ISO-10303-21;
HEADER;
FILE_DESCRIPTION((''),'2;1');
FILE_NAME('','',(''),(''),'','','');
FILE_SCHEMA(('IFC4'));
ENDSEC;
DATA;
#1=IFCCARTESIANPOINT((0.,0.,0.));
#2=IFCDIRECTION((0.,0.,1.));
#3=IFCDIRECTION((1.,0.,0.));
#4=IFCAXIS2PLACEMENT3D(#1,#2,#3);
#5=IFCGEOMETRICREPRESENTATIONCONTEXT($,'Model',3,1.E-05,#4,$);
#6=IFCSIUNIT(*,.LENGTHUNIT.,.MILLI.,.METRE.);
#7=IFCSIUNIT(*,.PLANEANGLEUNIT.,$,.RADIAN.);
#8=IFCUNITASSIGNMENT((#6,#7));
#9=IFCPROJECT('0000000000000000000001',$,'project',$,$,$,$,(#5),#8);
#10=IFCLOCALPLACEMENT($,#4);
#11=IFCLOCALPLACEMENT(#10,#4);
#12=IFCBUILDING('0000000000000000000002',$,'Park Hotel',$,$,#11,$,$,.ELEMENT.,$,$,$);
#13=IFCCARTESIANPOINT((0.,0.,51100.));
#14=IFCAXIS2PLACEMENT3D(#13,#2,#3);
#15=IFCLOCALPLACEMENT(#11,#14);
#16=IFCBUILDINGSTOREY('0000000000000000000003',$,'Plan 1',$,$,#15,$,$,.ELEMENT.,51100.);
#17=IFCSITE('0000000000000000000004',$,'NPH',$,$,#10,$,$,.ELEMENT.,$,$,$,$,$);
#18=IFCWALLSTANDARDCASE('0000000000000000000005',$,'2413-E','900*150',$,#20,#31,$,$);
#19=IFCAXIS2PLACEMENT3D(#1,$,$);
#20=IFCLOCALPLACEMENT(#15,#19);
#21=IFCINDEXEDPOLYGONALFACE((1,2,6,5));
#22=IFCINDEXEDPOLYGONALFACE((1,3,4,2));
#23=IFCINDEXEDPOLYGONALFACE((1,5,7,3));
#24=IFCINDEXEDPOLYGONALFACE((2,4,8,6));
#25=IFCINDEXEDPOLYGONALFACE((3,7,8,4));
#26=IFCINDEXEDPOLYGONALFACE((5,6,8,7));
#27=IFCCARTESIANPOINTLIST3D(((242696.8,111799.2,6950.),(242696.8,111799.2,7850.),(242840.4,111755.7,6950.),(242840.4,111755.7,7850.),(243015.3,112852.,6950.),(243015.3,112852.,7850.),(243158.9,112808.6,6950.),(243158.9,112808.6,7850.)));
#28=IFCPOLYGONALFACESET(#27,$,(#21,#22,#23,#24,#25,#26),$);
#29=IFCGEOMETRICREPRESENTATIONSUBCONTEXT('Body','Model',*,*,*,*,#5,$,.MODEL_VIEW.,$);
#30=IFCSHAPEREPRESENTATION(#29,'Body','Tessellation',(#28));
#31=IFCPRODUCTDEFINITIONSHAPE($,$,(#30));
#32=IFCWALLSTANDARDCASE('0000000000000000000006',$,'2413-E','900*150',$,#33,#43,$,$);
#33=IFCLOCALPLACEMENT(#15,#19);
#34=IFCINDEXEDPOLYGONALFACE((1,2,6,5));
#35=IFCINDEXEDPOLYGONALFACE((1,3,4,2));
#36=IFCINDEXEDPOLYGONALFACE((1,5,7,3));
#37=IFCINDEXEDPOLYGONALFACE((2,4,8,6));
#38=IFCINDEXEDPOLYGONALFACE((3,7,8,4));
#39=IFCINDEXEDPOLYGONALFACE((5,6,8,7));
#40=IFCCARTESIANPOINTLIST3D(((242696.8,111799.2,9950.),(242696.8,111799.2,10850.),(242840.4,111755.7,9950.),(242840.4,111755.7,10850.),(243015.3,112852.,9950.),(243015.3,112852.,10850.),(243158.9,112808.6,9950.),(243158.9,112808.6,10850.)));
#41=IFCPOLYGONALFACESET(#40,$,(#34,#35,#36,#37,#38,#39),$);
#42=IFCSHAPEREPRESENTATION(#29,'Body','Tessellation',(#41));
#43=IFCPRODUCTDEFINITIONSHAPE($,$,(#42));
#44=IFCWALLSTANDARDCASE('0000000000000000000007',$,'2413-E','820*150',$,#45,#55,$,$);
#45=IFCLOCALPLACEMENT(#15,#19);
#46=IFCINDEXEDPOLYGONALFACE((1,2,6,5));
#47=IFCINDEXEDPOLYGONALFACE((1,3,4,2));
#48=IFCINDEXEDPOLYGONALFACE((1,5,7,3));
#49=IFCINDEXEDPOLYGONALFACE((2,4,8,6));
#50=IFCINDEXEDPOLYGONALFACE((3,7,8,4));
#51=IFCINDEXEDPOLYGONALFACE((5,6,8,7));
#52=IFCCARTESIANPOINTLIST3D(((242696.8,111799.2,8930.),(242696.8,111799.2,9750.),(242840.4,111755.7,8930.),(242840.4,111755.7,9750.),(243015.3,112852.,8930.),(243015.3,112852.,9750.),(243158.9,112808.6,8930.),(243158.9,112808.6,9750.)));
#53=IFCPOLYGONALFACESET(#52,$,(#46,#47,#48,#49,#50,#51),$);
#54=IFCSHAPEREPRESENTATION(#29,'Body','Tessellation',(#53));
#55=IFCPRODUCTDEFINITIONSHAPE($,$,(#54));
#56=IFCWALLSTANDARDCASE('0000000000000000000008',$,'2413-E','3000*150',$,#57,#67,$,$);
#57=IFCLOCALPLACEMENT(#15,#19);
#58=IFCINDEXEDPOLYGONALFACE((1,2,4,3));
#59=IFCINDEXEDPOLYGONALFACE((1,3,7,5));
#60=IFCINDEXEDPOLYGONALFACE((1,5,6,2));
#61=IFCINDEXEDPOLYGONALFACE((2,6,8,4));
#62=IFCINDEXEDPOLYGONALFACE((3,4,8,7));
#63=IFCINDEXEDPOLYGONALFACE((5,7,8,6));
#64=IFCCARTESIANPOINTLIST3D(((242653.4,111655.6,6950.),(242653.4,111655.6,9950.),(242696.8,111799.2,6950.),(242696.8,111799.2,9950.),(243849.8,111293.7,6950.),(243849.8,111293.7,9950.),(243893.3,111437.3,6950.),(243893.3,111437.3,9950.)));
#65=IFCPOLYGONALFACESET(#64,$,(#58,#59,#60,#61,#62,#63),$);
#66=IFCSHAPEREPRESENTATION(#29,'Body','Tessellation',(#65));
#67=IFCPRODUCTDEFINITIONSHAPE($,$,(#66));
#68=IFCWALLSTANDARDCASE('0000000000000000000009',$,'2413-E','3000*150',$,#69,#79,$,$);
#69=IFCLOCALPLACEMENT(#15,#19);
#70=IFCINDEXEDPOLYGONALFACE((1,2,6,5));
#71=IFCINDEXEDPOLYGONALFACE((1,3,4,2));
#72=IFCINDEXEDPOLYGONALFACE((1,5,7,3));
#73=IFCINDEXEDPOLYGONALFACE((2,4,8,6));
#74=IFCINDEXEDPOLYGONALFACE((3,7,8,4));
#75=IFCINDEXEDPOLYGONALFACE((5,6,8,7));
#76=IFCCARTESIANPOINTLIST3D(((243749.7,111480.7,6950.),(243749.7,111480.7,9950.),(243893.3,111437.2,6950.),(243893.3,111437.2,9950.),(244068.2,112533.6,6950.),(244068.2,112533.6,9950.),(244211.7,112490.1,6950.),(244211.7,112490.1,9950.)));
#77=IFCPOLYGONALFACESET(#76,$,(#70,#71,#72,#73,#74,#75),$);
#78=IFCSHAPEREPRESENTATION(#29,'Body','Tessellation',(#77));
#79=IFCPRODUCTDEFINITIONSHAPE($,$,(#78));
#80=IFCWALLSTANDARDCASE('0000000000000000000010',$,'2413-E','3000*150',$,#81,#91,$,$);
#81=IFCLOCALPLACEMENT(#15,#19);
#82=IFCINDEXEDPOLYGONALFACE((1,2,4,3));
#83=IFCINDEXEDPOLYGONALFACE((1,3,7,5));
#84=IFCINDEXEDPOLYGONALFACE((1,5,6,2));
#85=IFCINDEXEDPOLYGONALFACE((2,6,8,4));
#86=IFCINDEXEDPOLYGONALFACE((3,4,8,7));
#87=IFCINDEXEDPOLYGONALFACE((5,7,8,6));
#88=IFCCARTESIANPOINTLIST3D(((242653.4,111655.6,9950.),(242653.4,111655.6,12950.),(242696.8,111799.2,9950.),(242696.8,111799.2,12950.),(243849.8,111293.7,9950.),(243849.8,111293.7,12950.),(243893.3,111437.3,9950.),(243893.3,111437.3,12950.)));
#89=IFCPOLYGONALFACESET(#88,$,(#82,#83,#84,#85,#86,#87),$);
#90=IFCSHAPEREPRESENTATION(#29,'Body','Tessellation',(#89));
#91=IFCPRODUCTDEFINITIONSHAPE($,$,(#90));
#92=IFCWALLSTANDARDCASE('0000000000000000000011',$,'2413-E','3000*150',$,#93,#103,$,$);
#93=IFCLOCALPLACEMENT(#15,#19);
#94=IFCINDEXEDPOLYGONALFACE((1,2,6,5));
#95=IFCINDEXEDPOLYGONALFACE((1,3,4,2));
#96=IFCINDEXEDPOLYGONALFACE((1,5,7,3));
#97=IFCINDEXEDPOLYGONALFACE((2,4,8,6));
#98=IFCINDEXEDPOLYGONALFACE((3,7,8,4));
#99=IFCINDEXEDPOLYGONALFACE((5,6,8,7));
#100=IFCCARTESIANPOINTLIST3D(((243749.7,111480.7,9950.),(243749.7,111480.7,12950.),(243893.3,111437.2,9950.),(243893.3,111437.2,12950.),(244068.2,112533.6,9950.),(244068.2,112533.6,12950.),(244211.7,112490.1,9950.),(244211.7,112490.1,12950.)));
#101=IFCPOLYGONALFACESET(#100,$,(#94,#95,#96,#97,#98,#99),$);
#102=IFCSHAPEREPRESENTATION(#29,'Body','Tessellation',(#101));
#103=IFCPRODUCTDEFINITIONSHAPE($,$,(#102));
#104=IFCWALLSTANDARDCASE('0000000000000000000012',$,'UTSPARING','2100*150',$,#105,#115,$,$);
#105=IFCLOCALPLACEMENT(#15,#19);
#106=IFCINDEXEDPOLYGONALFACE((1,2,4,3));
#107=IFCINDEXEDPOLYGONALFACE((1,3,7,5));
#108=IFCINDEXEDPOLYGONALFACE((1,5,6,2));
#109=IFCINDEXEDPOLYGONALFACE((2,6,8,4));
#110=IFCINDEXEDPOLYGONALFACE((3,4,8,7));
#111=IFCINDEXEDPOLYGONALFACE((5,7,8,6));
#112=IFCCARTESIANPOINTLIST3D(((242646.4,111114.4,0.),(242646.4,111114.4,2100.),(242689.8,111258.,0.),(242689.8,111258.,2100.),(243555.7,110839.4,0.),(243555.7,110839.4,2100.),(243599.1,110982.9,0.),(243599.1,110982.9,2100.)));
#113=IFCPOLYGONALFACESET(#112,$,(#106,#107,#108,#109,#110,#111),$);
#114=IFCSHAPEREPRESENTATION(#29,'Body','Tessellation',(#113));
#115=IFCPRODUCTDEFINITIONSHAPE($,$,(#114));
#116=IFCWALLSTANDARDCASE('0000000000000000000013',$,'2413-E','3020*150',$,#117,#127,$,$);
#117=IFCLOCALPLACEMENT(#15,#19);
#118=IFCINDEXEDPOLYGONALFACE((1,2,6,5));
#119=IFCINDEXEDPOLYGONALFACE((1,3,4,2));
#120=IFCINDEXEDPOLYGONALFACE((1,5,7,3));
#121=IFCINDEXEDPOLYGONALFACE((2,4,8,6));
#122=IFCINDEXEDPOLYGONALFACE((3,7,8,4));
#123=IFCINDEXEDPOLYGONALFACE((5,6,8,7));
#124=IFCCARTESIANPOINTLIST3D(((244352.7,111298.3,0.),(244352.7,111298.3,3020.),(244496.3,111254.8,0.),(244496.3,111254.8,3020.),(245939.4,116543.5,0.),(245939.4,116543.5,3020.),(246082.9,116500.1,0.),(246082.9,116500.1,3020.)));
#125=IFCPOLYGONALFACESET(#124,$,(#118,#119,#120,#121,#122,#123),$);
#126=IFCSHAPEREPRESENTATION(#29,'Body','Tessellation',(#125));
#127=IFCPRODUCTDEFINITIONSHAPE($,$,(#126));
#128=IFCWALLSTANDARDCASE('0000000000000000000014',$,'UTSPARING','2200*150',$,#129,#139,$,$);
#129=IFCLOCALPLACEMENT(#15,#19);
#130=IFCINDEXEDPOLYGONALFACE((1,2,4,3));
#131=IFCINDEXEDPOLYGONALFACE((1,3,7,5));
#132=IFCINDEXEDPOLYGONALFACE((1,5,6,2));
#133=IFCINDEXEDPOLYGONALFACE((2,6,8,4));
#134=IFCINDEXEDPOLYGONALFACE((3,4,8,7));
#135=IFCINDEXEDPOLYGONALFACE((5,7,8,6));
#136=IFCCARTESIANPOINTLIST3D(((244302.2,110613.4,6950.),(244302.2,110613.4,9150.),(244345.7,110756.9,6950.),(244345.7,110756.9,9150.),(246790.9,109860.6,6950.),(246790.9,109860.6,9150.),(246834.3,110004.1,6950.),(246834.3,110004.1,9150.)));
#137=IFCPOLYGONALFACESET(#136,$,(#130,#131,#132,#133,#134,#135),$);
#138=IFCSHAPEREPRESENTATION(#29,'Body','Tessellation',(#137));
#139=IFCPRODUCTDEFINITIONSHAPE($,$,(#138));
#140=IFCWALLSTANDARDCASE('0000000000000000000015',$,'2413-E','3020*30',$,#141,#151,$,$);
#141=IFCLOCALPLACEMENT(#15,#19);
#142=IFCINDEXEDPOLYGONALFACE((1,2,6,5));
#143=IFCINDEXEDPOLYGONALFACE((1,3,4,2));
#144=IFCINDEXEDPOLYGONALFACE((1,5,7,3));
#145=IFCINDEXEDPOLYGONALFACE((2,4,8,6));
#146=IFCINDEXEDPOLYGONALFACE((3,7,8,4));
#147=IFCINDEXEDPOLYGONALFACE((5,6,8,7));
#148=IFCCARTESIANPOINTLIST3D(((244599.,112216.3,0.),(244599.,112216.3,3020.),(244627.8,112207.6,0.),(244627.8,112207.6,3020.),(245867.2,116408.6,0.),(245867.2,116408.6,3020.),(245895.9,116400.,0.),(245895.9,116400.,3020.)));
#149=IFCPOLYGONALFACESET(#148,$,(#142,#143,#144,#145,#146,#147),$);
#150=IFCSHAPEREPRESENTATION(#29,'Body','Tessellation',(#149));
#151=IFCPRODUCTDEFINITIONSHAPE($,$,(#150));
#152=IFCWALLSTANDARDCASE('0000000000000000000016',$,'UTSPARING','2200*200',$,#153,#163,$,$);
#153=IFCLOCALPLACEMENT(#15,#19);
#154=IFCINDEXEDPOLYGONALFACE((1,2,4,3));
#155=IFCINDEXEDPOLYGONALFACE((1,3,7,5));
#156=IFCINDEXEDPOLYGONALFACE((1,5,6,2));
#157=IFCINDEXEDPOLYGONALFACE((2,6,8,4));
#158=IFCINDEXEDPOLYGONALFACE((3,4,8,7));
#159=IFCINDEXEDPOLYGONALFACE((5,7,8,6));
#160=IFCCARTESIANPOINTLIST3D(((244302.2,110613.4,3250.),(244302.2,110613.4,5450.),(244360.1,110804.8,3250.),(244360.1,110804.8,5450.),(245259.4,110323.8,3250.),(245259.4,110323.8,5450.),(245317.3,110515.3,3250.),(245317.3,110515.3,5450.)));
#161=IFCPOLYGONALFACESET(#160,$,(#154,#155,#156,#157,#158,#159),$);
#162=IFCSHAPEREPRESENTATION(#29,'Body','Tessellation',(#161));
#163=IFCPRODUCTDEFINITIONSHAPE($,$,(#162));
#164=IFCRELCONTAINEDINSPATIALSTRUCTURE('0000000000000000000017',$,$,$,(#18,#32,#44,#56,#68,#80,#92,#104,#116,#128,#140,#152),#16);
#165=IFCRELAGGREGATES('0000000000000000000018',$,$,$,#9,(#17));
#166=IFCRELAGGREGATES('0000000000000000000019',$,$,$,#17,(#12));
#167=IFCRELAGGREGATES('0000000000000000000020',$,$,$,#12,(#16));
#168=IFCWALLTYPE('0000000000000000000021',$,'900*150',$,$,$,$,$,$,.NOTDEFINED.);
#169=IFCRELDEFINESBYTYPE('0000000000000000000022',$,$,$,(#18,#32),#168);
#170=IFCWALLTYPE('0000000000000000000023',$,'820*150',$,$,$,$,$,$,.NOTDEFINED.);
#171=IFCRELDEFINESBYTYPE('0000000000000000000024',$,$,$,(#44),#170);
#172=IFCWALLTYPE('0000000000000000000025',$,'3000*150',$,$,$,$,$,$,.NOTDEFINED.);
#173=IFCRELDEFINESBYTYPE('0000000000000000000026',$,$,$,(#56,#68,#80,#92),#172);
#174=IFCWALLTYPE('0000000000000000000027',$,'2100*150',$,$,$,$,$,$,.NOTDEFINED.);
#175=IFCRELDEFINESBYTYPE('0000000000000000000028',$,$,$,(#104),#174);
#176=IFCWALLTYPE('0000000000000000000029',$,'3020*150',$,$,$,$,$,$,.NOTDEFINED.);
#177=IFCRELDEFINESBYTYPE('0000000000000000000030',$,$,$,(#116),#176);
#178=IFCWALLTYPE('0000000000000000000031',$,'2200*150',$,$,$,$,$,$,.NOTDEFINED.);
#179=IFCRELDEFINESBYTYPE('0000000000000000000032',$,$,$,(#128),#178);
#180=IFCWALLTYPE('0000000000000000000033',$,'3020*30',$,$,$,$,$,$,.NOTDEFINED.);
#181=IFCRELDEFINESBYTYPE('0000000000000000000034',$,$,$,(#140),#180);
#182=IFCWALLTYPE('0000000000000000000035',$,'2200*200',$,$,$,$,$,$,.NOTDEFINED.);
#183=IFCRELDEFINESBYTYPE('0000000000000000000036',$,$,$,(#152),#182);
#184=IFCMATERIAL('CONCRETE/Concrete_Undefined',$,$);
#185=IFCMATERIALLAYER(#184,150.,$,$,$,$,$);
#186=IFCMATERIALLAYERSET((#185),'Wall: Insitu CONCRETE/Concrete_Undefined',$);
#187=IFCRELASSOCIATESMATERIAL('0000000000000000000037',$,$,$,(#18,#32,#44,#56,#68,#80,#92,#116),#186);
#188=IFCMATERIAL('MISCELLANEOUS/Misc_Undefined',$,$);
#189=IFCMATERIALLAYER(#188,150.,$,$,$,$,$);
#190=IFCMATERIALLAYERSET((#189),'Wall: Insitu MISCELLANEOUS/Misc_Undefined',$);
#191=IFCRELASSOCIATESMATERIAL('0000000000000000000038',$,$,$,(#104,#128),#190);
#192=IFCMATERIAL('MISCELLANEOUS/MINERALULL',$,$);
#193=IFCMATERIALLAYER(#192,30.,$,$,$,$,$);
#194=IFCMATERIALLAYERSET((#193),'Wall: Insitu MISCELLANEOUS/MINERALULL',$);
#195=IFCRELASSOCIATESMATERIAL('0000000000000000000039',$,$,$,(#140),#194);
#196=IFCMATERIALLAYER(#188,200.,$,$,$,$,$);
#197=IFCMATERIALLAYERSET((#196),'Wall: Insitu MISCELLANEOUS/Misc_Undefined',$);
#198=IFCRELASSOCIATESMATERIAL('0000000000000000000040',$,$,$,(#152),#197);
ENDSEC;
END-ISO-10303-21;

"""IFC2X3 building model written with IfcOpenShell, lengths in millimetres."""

from ifc_helpers import new_model, si_unit, frame, frame_2d, origin_with_axes, place, context, subcontext, project, spatial, rectangle, extrude, material, layer, layer_set, layer_usage, type_object, element, save


model = new_model("IFC2X3")

# Units and contexts
model_context = context("Model", 3, precision=1e-05, world=origin_with_axes())
body_context = subcontext(model_context, "Body", "Model", "MODEL_VIEW")
ifc_project = project(units=[si_unit("LENGTHUNIT", "METRE", prefix="MILLI"), si_unit("PLANEANGLEUNIT", "RADIAN")], contexts=[model_context])

# Site, building, storey
site_placement = place(None, origin_with_axes())
site = spatial("IfcSite", under=ifc_project, at=site_placement, Name="NPH", CompositionType="ELEMENT")
building_placement = place(site_placement, origin_with_axes())
building = spatial("IfcBuilding", under=site, at=building_placement, Name="Park Hotel", CompositionType="ELEMENT")
storey_placement = place(building_placement, frame((0.0, 0.0, 51100.0), z_axis=(0.0, 0.0, 1.0), x_axis=(1.0, 0.0, 0.0)))
storey = spatial("IfcBuildingStorey", under=building, at=storey_placement, Name="Plan 1", CompositionType="ELEMENT", Elevation=51100.0)

# Shared definitions
ifc_material_1 = material(Name="CONCRETE/Concrete_Undefined")

# Walls
ifc_layer_1 = layer(ifc_material_1, 150.0)
ifc_layer_set_1 = layer_set([ifc_layer_1], Name="Wall: Insitu CONCRETE/Concrete_Undefined")
wall_type_1 = type_object("IfcWallType", Name="900*150", PredefinedType="NOTDEFINED")
ifc_layer_usage_1 = layer_usage(ifc_layer_set_1, "AXIS2", "POSITIVE", -75.0)
wall_1_placement = place(storey_placement, frame((242768.6, 111777.4, 6950.0), z_axis=(0.0, 0.0, 1.0), x_axis=(0.289534, 0.957168, 0.0)))
element("IfcWallStandardCase", 1, at=wall_1_placement, inside=storey, type_object=wall_type_1, material=ifc_layer_usage_1, Name="2413-E", Description="900*150", context=body_context, shape_type="SweptSolid", body=[
    extrude(rectangle(XDim=1100.0, YDim=150.0, at=frame_2d((0.0, 550.0), x_axis=(0.0, -1.0))), frame((0.0, 0.0, 0.0), z_axis=(0.0, 0.0, 1.0), x_axis=(0.0, -1.0, 0.0)), (0.0, 0.0, 1.0), 900.0),
])
ifc_layer_usage_2 = layer_usage(ifc_layer_set_1, "AXIS2", "POSITIVE", -75.0)
wall_2_placement = place(storey_placement, frame((242768.6, 111777.4, 9950.0), z_axis=(0.0, 0.0, 1.0), x_axis=(0.289534, 0.957168, 0.0)))
element("IfcWallStandardCase", 2, at=wall_2_placement, inside=storey, type_object=wall_type_1, material=ifc_layer_usage_2, Name="2413-E", Description="900*150", context=body_context, shape_type="SweptSolid", body=[
    extrude(rectangle(XDim=1100.0, YDim=150.0, at=frame_2d((0.0, 550.0), x_axis=(0.0, -1.0))), frame((0.0, 0.0, 0.0), z_axis=(0.0, 0.0, 1.0), x_axis=(0.0, -1.0, 0.0)), (0.0, 0.0, 1.0), 900.0),
])
ifc_layer_usage_3 = layer_usage(ifc_layer_set_1, "AXIS2", "POSITIVE", -75.0)
wall_type_2 = type_object("IfcWallType", Name="820*150", PredefinedType="NOTDEFINED")
wall_3_placement = place(storey_placement, frame((242768.6, 111777.4, 8930.0), z_axis=(0.0, 0.0, 1.0), x_axis=(0.289534, 0.957168, 0.0)))
element("IfcWallStandardCase", 3, at=wall_3_placement, inside=storey, type_object=wall_type_2, material=ifc_layer_usage_3, Name="2413-E", Description="820*150", context=body_context, shape_type="SweptSolid", body=[
    extrude(rectangle(XDim=1100.0, YDim=150.0, at=frame_2d((0.0, 550.0), x_axis=(0.0, -1.0))), frame((0.0, 0.0, 0.0), z_axis=(0.0, 0.0, 1.0), x_axis=(0.0, -1.0, 0.0)), (0.0, 0.0, 1.0), 820.0),
])
ifc_layer_usage_4 = layer_usage(ifc_layer_set_1, "AXIS2", "POSITIVE", -75.0)
wall_type_3 = type_object("IfcWallType", Name="3000*150", PredefinedType="NOTDEFINED")
wall_4_placement = place(storey_placement, frame((242675.1, 111727.4, 6950.0), z_axis=(0.0, 0.0, 1.0), x_axis=(0.957168, -0.289532, 0.0)))
element("IfcWallStandardCase", 4, at=wall_4_placement, inside=storey, type_object=wall_type_3, material=ifc_layer_usage_4, Name="2413-E", Description="3000*150", context=body_context, shape_type="SweptSolid", body=[
    extrude(rectangle(XDim=1250.0, YDim=150.0, at=frame_2d((0.0, 625.0), x_axis=(0.0, -1.0))), frame((0.0, 0.0, 0.0), z_axis=(0.0, 0.0, 1.0), x_axis=(0.0, -1.0, 0.0)), (0.0, 0.0, 1.0), 3000.0),
])
ifc_layer_usage_5 = layer_usage(ifc_layer_set_1, "AXIS2", "POSITIVE", -75.0)
wall_5_placement = place(storey_placement, frame((244140.0, 112511.8, 6950.0), z_axis=(0.0, 0.0, 1.0), x_axis=(-0.289534, -0.957168, 0.0)))
element("IfcWallStandardCase", 5, at=wall_5_placement, inside=storey, type_object=wall_type_3, material=ifc_layer_usage_5, Name="2413-E", Description="3000*150", context=body_context, shape_type="SweptSolid", body=[
    extrude(rectangle(XDim=1100.0, YDim=150.0, at=frame_2d((0.0, 550.0), x_axis=(0.0, -1.0))), frame((0.0, 0.0, 0.0), z_axis=(0.0, 0.0, 1.0), x_axis=(0.0, -1.0, 0.0)), (0.0, 0.0, 1.0), 3000.0),
])
ifc_layer_usage_6 = layer_usage(ifc_layer_set_1, "AXIS2", "POSITIVE", -75.0)
wall_6_placement = place(storey_placement, frame((242675.1, 111727.4, 9950.0), z_axis=(0.0, 0.0, 1.0), x_axis=(0.957168, -0.289532, 0.0)))
element("IfcWallStandardCase", 6, at=wall_6_placement, inside=storey, type_object=wall_type_3, material=ifc_layer_usage_6, Name="2413-E", Description="3000*150", context=body_context, shape_type="SweptSolid", body=[
    extrude(rectangle(XDim=1250.0, YDim=150.0, at=frame_2d((0.0, 625.0), x_axis=(0.0, -1.0))), frame((0.0, 0.0, 0.0), z_axis=(0.0, 0.0, 1.0), x_axis=(0.0, -1.0, 0.0)), (0.0, 0.0, 1.0), 3000.0),
])
ifc_layer_usage_7 = layer_usage(ifc_layer_set_1, "AXIS2", "POSITIVE", -75.0)
wall_7_placement = place(storey_placement, frame((244140.0, 112511.8, 9950.0), z_axis=(0.0, 0.0, 1.0), x_axis=(-0.289534, -0.957168, 0.0)))
element("IfcWallStandardCase", 7, at=wall_7_placement, inside=storey, type_object=wall_type_3, material=ifc_layer_usage_7, Name="2413-E", Description="3000*150", context=body_context, shape_type="SweptSolid", body=[
    extrude(rectangle(XDim=1100.0, YDim=150.0, at=frame_2d((0.0, 550.0), x_axis=(0.0, -1.0))), frame((0.0, 0.0, 0.0), z_axis=(0.0, 0.0, 1.0), x_axis=(0.0, -1.0, 0.0)), (0.0, 0.0, 1.0), 3000.0),
])
ifc_material_2 = material(Name="MISCELLANEOUS/Misc_Undefined")
ifc_layer_2 = layer(ifc_material_2, 150.0)
ifc_layer_set_2 = layer_set([ifc_layer_2], Name="Wall: Insitu MISCELLANEOUS/Misc_Undefined")
ifc_layer_usage_8 = layer_usage(ifc_layer_set_2, "AXIS2", "POSITIVE", -75.0)
wall_type_4 = type_object("IfcWallType", Name="2100*150", PredefinedType="NOTDEFINED")
wall_8_placement = place(storey_placement, frame((242668.1, 111186.2, 0.0), z_axis=(0.0, 0.0, 1.0), x_axis=(0.957166, -0.289541, 0.0)))
element("IfcWallStandardCase", 8, at=wall_8_placement, inside=storey, type_object=wall_type_4, material=ifc_layer_usage_8, Name="UTSPARING", Description="2100*150", context=body_context, shape_type="SweptSolid", body=[
    extrude(rectangle(XDim=950.0, YDim=150.0, at=frame_2d((0.0, 475.0), x_axis=(0.0, -1.0))), frame((0.0, 0.0, 0.0), z_axis=(0.0, 0.0, 1.0), x_axis=(0.0, -1.0, 0.0)), (0.0, 0.0, 1.0), 2100.0),
])
ifc_layer_usage_9 = layer_usage(ifc_layer_set_1, "AXIS2", "POSITIVE", -75.0)
wall_type_5 = type_object("IfcWallType", Name="3020*150", PredefinedType="NOTDEFINED")
wall_9_placement = place(storey_placement, frame((244424.5, 111276.5, 0.0), z_axis=(0.0, 0.0, 1.0), x_axis=(0.289537, 0.957167, 0.0)))
element("IfcWallStandardCase", 9, at=wall_9_placement, inside=storey, type_object=wall_type_5, material=ifc_layer_usage_9, Name="2413-E", Description="3020*150", context=body_context, shape_type="SweptSolid", body=[
    extrude(rectangle(XDim=5480.0, YDim=150.0, at=frame_2d((0.0, 2740.0), x_axis=(0.0, -1.0))), frame((0.0, 0.0, 0.0), z_axis=(0.0, 0.0, 1.0), x_axis=(0.0, -1.0, 0.0)), (0.0, 0.0, 1.0), 3020.0),
])
ifc_layer_usage_10 = layer_usage(ifc_layer_set_2, "AXIS2", "POSITIVE", -75.0)
wall_type_6 = type_object("IfcWallType", Name="2200*150", PredefinedType="NOTDEFINED")
wall_10_placement = place(storey_placement, frame((244324.0, 110685.2, 6950.0), z_axis=(0.0, 0.0, 1.0), x_axis=(0.957166, -0.289539, 0.0)))
element("IfcWallStandardCase", 10, at=wall_10_placement, inside=storey, type_object=wall_type_6, material=ifc_layer_usage_10, Name="UTSPARING", Description="2200*150", context=body_context, shape_type="SweptSolid", body=[
    extrude(rectangle(XDim=2600.0, YDim=150.0, at=frame_2d((0.0, 1300.0), x_axis=(0.0, -1.0))), frame((0.0, 0.0, 0.0), z_axis=(0.0, 0.0, 1.0), x_axis=(0.0, -1.0, 0.0)), (0.0, 0.0, 1.0), 2200.0),
])
ifc_material_3 = material(Name="MISCELLANEOUS/MINERALULL")
ifc_layer_3 = layer(ifc_material_3, 30.0)
ifc_layer_set_3 = layer_set([ifc_layer_3], Name="Wall: Insitu MISCELLANEOUS/MINERALULL")
ifc_layer_usage_11 = layer_usage(ifc_layer_set_3, "AXIS2", "POSITIVE", -15.0)
wall_type_7 = type_object("IfcWallType", Name="3020*30", PredefinedType="NOTDEFINED")
wall_11_placement = place(storey_placement, frame((244613.4, 112211.9, 0.0), z_axis=(0.0, 0.0, 1.0), x_axis=(0.289537, 0.957167, 0.0)))
element("IfcWallStandardCase", 11, at=wall_11_placement, inside=storey, type_object=wall_type_7, material=ifc_layer_usage_11, Name="2413-E", Description="3020*30", context=body_context, shape_type="SweptSolid", body=[
    extrude(rectangle(XDim=4380.0, YDim=30.0, at=frame_2d((0.0, 2190.0), x_axis=(0.0, -1.0))), frame((0.0, 0.0, 0.0), z_axis=(0.0, 0.0, 1.0), x_axis=(0.0, -1.0, 0.0)), (0.0, 0.0, 1.0), 3020.0),
])
ifc_layer_4 = layer(ifc_material_2, 200.0)
ifc_layer_set_4 = layer_set([ifc_layer_4], Name="Wall: Insitu MISCELLANEOUS/Misc_Undefined")
ifc_layer_usage_12 = layer_usage(ifc_layer_set_4, "AXIS2", "POSITIVE", -100.0)
wall_type_8 = type_object("IfcWallType", Name="2200*200", PredefinedType="NOTDEFINED")
wall_12_placement = place(storey_placement, frame((244331.2, 110709.1, 3250.0), z_axis=(0.0, 0.0, 1.0), x_axis=(0.957166, -0.289541, 0.0)))
element("IfcWallStandardCase", 12, at=wall_12_placement, inside=storey, type_object=wall_type_8, material=ifc_layer_usage_12, Name="UTSPARING", Description="2200*200", context=body_context, shape_type="SweptSolid", body=[
    extrude(rectangle(XDim=1000.0, YDim=200.0, at=frame_2d((0.0, 500.0), x_axis=(0.0, -1.0))), frame((0.0, 0.0, 0.0), z_axis=(0.0, 0.0, 1.0), x_axis=(0.0, -1.0, 0.0)), (0.0, 0.0, 1.0), 2200.0),
])

save(model, "model.ifc")
